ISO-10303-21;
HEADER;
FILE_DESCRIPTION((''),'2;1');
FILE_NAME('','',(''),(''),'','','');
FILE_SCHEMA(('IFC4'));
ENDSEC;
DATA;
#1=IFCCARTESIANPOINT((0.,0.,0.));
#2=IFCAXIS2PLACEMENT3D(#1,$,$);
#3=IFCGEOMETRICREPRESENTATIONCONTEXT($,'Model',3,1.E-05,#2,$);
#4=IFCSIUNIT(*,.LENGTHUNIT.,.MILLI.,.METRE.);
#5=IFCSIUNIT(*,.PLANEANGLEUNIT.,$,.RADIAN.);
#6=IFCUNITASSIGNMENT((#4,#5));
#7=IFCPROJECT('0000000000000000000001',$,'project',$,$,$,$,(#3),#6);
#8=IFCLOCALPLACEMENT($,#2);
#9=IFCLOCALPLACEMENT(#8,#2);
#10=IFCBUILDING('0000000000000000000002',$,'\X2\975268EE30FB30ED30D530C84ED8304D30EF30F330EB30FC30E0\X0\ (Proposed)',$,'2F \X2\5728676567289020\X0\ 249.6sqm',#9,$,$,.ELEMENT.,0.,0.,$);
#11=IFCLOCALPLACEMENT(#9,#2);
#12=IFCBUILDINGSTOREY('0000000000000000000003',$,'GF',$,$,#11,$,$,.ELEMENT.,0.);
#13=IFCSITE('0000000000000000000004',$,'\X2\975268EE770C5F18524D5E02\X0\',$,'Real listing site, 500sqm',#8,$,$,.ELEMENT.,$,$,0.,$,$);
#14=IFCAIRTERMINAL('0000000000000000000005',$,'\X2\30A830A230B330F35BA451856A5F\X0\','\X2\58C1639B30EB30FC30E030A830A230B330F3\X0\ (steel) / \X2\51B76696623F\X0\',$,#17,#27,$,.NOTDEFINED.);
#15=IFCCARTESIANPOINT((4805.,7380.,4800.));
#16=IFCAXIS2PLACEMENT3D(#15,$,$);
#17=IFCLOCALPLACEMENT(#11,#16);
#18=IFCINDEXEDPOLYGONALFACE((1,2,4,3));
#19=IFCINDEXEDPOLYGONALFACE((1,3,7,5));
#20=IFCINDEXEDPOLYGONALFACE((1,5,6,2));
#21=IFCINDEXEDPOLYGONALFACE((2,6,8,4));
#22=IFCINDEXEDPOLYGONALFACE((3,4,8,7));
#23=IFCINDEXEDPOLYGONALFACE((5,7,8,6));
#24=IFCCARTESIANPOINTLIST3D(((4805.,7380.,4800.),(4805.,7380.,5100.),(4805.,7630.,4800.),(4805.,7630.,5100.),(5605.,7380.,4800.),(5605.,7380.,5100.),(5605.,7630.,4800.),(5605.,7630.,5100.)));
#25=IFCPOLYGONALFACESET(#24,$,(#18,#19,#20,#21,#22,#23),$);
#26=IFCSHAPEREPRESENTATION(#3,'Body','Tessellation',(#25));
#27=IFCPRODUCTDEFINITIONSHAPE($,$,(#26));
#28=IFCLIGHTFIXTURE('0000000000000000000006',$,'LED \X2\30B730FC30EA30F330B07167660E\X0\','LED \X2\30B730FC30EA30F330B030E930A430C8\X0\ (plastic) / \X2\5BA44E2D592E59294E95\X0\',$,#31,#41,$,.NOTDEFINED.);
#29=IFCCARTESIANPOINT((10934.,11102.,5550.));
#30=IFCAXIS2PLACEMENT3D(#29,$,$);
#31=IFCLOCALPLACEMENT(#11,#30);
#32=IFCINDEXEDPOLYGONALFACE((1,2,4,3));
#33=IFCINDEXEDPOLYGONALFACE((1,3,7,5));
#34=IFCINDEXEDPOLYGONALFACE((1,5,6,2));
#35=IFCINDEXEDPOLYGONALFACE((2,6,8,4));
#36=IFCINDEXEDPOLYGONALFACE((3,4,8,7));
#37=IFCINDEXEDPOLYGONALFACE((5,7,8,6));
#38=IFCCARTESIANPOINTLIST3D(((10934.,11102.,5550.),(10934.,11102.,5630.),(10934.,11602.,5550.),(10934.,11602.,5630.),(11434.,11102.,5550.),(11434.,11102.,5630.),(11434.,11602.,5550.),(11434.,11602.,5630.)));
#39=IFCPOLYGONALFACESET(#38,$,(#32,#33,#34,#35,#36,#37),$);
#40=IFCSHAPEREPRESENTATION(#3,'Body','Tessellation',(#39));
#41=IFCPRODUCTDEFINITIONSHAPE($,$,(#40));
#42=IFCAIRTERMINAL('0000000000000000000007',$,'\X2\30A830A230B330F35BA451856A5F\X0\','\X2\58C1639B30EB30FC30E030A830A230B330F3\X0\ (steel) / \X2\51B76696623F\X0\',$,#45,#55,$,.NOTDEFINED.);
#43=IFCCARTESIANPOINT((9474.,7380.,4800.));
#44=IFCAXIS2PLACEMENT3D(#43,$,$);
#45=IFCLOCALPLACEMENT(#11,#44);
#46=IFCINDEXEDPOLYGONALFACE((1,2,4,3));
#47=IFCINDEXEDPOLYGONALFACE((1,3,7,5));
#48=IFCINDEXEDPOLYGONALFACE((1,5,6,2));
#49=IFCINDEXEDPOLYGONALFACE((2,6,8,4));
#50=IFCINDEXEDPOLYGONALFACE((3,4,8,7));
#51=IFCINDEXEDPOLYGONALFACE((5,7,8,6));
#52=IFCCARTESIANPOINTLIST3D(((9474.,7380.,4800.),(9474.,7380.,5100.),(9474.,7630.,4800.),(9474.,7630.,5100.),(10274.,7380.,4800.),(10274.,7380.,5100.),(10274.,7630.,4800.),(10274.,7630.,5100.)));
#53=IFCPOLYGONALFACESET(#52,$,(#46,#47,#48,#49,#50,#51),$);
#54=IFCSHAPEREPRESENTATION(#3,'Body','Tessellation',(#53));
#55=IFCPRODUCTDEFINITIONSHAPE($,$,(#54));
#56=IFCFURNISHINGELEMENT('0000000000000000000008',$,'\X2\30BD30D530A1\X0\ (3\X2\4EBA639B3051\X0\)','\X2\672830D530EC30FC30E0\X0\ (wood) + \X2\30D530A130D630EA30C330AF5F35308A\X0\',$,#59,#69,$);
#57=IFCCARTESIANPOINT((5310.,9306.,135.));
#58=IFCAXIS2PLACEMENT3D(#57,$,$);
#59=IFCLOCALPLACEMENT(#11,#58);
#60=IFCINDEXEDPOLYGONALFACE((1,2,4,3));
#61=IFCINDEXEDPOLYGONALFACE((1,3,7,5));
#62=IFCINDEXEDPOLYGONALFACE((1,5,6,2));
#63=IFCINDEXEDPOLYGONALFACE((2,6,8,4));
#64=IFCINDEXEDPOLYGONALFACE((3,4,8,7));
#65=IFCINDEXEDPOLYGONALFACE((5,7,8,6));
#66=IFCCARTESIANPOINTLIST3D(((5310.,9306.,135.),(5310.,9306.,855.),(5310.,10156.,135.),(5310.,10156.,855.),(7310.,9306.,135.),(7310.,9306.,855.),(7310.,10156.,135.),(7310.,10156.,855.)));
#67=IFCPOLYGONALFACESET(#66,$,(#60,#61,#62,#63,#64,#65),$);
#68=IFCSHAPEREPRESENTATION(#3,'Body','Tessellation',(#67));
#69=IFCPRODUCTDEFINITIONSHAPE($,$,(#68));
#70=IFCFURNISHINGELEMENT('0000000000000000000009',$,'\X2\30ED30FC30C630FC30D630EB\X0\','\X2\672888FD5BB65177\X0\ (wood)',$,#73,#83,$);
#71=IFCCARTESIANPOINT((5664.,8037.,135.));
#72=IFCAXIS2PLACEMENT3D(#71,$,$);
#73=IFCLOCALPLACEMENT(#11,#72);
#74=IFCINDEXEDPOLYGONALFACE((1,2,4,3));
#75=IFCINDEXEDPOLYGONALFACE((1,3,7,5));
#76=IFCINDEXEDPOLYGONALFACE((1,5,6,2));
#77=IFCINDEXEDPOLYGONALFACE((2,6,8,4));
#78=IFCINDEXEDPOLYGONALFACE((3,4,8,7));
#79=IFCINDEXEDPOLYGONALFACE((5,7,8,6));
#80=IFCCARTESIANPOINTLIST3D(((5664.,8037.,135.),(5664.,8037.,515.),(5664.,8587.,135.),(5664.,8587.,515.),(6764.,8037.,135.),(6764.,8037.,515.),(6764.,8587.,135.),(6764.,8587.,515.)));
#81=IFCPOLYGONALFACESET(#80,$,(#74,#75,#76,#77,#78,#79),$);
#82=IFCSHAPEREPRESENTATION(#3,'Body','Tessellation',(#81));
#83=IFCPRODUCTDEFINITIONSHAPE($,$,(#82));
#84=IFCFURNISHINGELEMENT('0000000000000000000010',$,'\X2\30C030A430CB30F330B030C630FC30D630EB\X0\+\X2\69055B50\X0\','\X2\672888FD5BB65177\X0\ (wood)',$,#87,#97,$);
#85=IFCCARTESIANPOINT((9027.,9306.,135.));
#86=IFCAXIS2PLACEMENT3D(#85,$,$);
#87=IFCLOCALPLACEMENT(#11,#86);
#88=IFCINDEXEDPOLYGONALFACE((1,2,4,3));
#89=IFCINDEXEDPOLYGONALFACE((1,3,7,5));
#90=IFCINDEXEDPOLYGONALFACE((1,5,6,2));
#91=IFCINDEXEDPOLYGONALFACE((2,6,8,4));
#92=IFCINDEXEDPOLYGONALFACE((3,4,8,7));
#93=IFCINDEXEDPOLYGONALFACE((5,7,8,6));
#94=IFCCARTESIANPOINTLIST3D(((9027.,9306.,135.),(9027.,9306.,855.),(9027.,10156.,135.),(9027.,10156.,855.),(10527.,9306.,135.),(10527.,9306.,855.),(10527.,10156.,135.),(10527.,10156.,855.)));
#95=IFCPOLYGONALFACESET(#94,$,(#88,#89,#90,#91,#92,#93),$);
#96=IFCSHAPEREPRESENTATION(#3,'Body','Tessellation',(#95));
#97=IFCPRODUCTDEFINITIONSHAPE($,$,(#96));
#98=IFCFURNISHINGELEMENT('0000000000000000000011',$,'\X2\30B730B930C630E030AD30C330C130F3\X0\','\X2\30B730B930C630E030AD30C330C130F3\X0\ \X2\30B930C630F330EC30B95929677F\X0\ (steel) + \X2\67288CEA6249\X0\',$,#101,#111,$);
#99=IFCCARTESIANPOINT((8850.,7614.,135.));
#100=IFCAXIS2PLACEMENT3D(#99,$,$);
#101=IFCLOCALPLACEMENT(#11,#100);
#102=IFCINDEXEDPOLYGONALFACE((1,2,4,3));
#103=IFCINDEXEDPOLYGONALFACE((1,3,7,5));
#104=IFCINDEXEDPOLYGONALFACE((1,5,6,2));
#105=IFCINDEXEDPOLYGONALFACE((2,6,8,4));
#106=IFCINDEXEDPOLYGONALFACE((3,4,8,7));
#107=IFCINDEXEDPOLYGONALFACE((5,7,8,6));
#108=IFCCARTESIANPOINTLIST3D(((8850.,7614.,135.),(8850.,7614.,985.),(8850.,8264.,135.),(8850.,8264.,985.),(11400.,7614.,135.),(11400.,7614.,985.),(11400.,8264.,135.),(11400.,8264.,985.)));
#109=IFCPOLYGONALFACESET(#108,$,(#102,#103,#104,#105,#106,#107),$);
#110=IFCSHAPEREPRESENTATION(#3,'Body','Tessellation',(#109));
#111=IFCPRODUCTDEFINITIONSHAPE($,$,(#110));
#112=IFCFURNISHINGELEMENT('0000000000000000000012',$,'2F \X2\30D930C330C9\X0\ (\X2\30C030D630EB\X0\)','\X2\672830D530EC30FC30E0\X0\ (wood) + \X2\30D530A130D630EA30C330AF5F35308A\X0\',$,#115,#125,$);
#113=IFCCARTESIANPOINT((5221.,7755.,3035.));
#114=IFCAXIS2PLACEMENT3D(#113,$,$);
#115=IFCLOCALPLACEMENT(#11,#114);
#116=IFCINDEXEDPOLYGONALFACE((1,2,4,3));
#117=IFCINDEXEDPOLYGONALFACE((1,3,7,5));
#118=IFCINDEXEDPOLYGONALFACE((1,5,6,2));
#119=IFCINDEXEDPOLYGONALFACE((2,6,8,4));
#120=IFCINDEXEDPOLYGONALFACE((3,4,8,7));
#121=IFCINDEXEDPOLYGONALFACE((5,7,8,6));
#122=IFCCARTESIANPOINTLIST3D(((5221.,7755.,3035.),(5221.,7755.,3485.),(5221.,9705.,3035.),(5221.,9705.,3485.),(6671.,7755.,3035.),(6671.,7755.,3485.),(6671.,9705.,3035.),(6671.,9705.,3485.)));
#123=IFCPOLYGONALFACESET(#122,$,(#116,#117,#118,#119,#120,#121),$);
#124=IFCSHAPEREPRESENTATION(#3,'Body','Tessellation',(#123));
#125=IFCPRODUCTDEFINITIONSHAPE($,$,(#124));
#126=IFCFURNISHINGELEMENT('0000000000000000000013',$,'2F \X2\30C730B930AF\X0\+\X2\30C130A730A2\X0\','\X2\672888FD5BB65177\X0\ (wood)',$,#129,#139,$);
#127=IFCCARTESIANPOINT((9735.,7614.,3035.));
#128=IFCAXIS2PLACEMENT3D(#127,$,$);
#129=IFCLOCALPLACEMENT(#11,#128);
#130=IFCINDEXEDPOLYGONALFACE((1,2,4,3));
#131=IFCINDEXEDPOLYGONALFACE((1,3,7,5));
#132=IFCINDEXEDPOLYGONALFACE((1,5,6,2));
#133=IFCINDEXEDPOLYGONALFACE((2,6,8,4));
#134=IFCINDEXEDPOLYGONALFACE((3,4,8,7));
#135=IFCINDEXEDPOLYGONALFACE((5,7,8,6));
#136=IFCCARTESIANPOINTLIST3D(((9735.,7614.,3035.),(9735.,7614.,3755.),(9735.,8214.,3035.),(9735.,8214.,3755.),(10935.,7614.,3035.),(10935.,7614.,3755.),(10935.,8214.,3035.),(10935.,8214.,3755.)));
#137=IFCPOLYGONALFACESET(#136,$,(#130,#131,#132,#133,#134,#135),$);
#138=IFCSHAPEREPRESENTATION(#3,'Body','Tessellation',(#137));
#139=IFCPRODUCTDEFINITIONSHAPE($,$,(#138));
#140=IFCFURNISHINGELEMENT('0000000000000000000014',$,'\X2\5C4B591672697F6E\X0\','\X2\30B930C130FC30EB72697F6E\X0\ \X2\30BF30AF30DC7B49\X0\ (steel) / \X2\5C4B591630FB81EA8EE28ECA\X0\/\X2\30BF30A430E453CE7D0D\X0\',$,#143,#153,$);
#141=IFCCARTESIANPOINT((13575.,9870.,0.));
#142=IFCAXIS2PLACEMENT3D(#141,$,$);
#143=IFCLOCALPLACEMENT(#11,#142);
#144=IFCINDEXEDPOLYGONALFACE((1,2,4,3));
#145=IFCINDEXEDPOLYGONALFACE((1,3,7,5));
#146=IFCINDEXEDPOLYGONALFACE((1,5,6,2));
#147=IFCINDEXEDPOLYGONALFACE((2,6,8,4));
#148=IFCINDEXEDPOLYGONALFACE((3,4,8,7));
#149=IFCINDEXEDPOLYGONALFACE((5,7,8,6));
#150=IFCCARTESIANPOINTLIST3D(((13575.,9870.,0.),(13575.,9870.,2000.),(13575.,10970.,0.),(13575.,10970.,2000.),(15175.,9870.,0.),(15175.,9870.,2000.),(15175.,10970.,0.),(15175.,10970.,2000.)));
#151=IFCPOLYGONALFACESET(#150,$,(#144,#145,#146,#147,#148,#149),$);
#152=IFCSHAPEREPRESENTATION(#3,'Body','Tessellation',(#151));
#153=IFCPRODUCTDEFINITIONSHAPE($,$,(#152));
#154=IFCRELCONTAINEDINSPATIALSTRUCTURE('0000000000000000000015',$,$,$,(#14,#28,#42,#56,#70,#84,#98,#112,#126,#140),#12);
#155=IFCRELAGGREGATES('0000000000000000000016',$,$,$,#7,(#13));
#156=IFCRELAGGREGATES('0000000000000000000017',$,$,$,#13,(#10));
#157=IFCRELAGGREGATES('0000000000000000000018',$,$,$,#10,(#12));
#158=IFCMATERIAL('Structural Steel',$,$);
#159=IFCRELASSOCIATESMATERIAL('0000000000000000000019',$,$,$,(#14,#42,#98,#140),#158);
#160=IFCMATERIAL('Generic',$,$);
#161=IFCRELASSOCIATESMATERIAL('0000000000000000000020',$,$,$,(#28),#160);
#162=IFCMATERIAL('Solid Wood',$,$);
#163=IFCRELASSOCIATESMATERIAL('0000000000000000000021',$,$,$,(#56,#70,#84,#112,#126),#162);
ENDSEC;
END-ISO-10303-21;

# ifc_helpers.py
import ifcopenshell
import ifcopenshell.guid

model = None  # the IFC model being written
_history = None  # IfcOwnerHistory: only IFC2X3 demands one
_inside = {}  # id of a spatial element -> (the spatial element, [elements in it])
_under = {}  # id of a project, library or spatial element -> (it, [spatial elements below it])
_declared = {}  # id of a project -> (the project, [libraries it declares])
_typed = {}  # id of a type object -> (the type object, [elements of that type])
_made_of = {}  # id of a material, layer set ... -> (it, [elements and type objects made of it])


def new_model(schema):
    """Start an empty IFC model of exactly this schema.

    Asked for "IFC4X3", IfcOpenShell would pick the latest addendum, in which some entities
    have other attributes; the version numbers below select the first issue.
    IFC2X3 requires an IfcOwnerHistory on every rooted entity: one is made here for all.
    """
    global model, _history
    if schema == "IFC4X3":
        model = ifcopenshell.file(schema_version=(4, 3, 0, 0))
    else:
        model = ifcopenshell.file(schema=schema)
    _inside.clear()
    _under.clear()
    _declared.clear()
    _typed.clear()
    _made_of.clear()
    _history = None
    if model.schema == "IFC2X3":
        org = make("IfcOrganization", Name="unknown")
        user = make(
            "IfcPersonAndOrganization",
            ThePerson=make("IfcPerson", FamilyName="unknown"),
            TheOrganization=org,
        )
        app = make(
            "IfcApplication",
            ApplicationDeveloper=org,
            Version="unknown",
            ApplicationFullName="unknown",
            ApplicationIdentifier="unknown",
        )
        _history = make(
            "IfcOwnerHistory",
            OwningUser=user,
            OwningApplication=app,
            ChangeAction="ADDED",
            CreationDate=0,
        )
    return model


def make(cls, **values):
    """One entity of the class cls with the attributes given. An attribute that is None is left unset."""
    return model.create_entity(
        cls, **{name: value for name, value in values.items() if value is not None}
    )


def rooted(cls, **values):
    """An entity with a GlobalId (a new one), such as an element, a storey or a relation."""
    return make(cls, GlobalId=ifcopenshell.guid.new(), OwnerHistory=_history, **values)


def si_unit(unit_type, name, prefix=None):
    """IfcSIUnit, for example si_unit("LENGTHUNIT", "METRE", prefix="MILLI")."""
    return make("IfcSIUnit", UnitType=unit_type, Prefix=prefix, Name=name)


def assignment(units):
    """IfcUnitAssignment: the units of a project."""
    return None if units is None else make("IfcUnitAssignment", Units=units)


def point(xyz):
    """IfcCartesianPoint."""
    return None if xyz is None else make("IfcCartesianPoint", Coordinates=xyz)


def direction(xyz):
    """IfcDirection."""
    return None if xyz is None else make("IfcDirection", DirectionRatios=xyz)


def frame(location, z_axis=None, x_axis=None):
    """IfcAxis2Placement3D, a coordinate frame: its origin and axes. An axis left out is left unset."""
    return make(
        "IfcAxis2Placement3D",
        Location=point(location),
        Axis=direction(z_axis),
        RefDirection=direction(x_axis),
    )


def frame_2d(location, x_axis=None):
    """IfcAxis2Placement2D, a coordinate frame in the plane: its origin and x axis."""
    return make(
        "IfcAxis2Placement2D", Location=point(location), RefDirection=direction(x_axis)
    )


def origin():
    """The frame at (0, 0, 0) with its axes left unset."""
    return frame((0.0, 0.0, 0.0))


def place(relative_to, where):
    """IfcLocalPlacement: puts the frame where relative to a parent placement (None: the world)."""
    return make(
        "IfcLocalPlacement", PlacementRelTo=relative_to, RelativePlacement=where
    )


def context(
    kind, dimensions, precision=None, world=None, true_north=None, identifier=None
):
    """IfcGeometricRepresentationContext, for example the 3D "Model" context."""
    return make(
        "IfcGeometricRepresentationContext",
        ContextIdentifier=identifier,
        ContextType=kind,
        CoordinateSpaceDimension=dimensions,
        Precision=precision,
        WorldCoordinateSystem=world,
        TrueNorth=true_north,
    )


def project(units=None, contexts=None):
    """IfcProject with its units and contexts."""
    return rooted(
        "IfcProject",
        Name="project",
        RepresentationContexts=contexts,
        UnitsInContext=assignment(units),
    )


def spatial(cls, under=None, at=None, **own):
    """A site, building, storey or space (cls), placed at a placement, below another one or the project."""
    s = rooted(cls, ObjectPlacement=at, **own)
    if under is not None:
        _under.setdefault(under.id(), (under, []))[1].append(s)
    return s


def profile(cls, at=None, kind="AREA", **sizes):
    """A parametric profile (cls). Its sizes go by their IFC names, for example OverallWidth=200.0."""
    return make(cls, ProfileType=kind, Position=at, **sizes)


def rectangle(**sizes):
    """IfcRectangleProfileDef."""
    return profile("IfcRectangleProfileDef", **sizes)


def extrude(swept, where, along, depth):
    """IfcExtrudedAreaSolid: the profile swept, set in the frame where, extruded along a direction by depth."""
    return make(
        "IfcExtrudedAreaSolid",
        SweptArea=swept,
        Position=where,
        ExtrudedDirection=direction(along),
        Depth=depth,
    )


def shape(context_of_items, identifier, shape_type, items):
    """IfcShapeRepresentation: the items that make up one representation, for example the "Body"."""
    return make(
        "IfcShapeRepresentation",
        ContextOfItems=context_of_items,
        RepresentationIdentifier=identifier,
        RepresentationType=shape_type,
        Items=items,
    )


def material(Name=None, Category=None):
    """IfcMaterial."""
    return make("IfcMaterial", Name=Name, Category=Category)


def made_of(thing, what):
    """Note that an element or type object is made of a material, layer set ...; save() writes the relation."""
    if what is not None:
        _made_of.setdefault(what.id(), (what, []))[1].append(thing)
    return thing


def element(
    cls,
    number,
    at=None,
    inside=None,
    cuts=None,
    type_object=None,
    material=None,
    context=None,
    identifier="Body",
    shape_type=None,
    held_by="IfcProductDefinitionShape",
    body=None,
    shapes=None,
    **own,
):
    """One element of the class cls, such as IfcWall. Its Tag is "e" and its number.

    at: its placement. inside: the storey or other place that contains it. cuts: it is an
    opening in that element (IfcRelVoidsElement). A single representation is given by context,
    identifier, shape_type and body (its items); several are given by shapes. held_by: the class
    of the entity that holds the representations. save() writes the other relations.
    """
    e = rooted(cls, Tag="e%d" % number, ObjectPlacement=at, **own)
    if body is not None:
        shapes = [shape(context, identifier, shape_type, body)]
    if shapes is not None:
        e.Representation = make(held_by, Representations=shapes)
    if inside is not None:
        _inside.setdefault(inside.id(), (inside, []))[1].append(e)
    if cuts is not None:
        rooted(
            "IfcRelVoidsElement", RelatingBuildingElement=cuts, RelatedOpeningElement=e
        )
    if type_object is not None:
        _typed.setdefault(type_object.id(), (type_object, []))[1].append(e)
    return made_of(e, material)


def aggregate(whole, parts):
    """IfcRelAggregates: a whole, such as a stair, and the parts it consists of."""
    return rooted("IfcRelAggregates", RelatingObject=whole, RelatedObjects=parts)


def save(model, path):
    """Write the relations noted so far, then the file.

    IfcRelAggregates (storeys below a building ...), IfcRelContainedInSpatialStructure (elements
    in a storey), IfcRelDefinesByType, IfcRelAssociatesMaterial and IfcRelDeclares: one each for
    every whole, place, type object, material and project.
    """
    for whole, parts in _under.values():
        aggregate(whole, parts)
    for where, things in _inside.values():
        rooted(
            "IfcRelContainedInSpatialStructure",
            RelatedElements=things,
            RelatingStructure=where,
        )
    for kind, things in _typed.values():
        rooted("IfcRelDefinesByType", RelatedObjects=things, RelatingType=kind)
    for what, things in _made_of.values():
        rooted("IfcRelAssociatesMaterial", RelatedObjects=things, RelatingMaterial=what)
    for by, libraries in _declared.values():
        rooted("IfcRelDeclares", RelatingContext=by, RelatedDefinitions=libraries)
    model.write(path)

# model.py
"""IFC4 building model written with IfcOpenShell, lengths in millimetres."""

from ifc_helpers import new_model, si_unit, frame, frame_2d, origin, place, context, project, spatial, rectangle, extrude, material, element, save


model = new_model("IFC4")

# Units and contexts
model_context = context("Model", 3, precision=1e-05, world=origin())
ifc_project = project(units=[si_unit("LENGTHUNIT", "METRE", prefix="MILLI"), si_unit("PLANEANGLEUNIT", "RADIAN")], contexts=[model_context])

# Site, building, storey
site_placement = place(None, origin())
site = spatial("IfcSite", under=ifc_project, at=site_placement, Name="青森県弘前市", ObjectType="Real listing site, 500sqm", CompositionType="ELEMENT", RefElevation=0.0)
building_placement = place(site_placement, origin())
building = spatial("IfcBuilding", under=site, at=building_placement, Name="青森・ロフト付きワンルーム (Proposed)", ObjectType="2F 在来木造 249.6sqm", CompositionType="ELEMENT", ElevationOfRefHeight=0.0, ElevationOfTerrain=0.0)
storey_placement = place(building_placement, origin())
storey = spatial("IfcBuildingStorey", under=building, at=storey_placement, Name="GF", CompositionType="ELEMENT", Elevation=0.0)

# Shared definitions
ifc_material_1 = material(Name="Solid Wood")

# Shared definitions
ifc_material_2 = material(Name="Generic")

# Shared definitions
ifc_material_3 = material(Name="Structural Steel")

# Air terminal
air_terminal_1_placement = place(storey_placement, frame((4805.0, 7380.0, 4800.0)))
element("IfcAirTerminal", 1, at=air_terminal_1_placement, inside=storey, material=ifc_material_3, Name="エアコン室内機", Description="壁掛ルームエアコン (steel) / 冷暖房", PredefinedType="NOTDEFINED", context=model_context, shape_type="SweptSolid", body=[
    extrude(rectangle(XDim=800.0, YDim=250.0, at=frame_2d((400.0, 125.0))), frame((4805.0, 7380.0, 4800.0)), (0.0, 0.0, 1.0), 300.0),
])

# Light fixture
light_fixture_1_placement = place(storey_placement, frame((10934.0, 11102.0, 5550.0)))
element("IfcLightFixture", 2, at=light_fixture_1_placement, inside=storey, material=ifc_material_2, Name="LED シーリング照明", Description="LED シーリングライト (plastic) / 室中央天井", PredefinedType="NOTDEFINED", context=model_context, shape_type="SweptSolid", body=[
    extrude(rectangle(XDim=500.0, YDim=500.0, at=frame_2d((250.0, 250.0))), frame((10934.0, 11102.0, 5550.0)), (0.0, 0.0, 1.0), 80.0),
])

# Air terminal
air_terminal_2_placement = place(storey_placement, frame((9474.0, 7380.0, 4800.0)))
element("IfcAirTerminal", 3, at=air_terminal_2_placement, inside=storey, material=ifc_material_3, Name="エアコン室内機", Description="壁掛ルームエアコン (steel) / 冷暖房", PredefinedType="NOTDEFINED", context=model_context, shape_type="SweptSolid", body=[
    extrude(rectangle(XDim=800.0, YDim=250.0, at=frame_2d((400.0, 125.0))), frame((9474.0, 7380.0, 4800.0)), (0.0, 0.0, 1.0), 300.0),
])

# Furnishing elements
furnishing_1_placement = place(storey_placement, frame((5310.0, 9306.0, 135.0)))
element("IfcFurnishingElement", 4, at=furnishing_1_placement, inside=storey, material=ifc_material_1, Name="ソファ (3人掛け)", Description="木フレーム (wood) + ファブリック張り", context=model_context, shape_type="SweptSolid", body=[
    extrude(rectangle(XDim=2000.0, YDim=850.0, at=frame_2d((1000.0, 425.0))), frame((5310.0, 9306.0, 135.0)), (0.0, 0.0, 1.0), 720.0),
])
furnishing_2_placement = place(storey_placement, frame((5664.0, 8037.0, 135.0)))
element("IfcFurnishingElement", 5, at=furnishing_2_placement, inside=storey, material=ifc_material_1, Name="ローテーブル", Description="木製家具 (wood)", context=model_context, shape_type="SweptSolid", body=[
    extrude(rectangle(XDim=1100.0, YDim=550.0, at=frame_2d((550.0, 275.0))), frame((5664.0, 8037.0, 135.0)), (0.0, 0.0, 1.0), 380.0),
])
furnishing_3_placement = place(storey_placement, frame((9027.0, 9306.0, 135.0)))
element("IfcFurnishingElement", 6, at=furnishing_3_placement, inside=storey, material=ifc_material_1, Name="ダイニングテーブル+椅子", Description="木製家具 (wood)", context=model_context, shape_type="SweptSolid", body=[
    extrude(rectangle(XDim=1500.0, YDim=850.0, at=frame_2d((750.0, 425.0))), frame((9027.0, 9306.0, 135.0)), (0.0, 0.0, 1.0), 720.0),
])
furnishing_4_placement = place(storey_placement, frame((8850.0, 7614.0, 135.0)))
element("IfcFurnishingElement", 7, at=furnishing_4_placement, inside=storey, material=ifc_material_3, Name="システムキッチン", Description="システムキッチン ステンレス天板 (steel) + 木質扉", context=model_context, shape_type="SweptSolid", body=[
    extrude(rectangle(XDim=2550.0, YDim=650.0, at=frame_2d((1275.0, 325.0))), frame((8850.0, 7614.0, 135.0)), (0.0, 0.0, 1.0), 850.0),
])
furnishing_5_placement = place(storey_placement, frame((5221.0, 7755.0, 3035.0)))
element("IfcFurnishingElement", 8, at=furnishing_5_placement, inside=storey, material=ifc_material_1, Name="2F ベッド (ダブル)", Description="木フレーム (wood) + ファブリック張り", context=model_context, shape_type="SweptSolid", body=[
    extrude(rectangle(XDim=1450.0, YDim=1950.0, at=frame_2d((725.0, 975.0))), frame((5221.0, 7755.0, 3035.0)), (0.0, 0.0, 1.0), 450.0),
])
furnishing_6_placement = place(storey_placement, frame((9735.0, 7614.0, 3035.0)))
element("IfcFurnishingElement", 9, at=furnishing_6_placement, inside=storey, material=ifc_material_1, Name="2F デスク+チェア", Description="木製家具 (wood)", context=model_context, shape_type="SweptSolid", body=[
    extrude(rectangle(XDim=1200.0, YDim=600.0, at=frame_2d((600.0, 300.0))), frame((9735.0, 7614.0, 3035.0)), (0.0, 0.0, 1.0), 720.0),
])
furnishing_7_placement = place(storey_placement, frame((13575.0, 9870.0, 0.0)))
element("IfcFurnishingElement", 10, at=furnishing_7_placement, inside=storey, material=ifc_material_3, Name="屋外物置", Description="スチール物置 タクボ等 (steel) / 屋外・自転車/タイヤ収納", context=model_context, shape_type="SweptSolid", body=[
    extrude(rectangle(XDim=1600.0, YDim=1100.0, at=frame_2d((800.0, 550.0))), frame((13575.0, 9870.0, 0.0)), (0.0, 0.0, 1.0), 2000.0),
])

save(model, "model.ifc")
